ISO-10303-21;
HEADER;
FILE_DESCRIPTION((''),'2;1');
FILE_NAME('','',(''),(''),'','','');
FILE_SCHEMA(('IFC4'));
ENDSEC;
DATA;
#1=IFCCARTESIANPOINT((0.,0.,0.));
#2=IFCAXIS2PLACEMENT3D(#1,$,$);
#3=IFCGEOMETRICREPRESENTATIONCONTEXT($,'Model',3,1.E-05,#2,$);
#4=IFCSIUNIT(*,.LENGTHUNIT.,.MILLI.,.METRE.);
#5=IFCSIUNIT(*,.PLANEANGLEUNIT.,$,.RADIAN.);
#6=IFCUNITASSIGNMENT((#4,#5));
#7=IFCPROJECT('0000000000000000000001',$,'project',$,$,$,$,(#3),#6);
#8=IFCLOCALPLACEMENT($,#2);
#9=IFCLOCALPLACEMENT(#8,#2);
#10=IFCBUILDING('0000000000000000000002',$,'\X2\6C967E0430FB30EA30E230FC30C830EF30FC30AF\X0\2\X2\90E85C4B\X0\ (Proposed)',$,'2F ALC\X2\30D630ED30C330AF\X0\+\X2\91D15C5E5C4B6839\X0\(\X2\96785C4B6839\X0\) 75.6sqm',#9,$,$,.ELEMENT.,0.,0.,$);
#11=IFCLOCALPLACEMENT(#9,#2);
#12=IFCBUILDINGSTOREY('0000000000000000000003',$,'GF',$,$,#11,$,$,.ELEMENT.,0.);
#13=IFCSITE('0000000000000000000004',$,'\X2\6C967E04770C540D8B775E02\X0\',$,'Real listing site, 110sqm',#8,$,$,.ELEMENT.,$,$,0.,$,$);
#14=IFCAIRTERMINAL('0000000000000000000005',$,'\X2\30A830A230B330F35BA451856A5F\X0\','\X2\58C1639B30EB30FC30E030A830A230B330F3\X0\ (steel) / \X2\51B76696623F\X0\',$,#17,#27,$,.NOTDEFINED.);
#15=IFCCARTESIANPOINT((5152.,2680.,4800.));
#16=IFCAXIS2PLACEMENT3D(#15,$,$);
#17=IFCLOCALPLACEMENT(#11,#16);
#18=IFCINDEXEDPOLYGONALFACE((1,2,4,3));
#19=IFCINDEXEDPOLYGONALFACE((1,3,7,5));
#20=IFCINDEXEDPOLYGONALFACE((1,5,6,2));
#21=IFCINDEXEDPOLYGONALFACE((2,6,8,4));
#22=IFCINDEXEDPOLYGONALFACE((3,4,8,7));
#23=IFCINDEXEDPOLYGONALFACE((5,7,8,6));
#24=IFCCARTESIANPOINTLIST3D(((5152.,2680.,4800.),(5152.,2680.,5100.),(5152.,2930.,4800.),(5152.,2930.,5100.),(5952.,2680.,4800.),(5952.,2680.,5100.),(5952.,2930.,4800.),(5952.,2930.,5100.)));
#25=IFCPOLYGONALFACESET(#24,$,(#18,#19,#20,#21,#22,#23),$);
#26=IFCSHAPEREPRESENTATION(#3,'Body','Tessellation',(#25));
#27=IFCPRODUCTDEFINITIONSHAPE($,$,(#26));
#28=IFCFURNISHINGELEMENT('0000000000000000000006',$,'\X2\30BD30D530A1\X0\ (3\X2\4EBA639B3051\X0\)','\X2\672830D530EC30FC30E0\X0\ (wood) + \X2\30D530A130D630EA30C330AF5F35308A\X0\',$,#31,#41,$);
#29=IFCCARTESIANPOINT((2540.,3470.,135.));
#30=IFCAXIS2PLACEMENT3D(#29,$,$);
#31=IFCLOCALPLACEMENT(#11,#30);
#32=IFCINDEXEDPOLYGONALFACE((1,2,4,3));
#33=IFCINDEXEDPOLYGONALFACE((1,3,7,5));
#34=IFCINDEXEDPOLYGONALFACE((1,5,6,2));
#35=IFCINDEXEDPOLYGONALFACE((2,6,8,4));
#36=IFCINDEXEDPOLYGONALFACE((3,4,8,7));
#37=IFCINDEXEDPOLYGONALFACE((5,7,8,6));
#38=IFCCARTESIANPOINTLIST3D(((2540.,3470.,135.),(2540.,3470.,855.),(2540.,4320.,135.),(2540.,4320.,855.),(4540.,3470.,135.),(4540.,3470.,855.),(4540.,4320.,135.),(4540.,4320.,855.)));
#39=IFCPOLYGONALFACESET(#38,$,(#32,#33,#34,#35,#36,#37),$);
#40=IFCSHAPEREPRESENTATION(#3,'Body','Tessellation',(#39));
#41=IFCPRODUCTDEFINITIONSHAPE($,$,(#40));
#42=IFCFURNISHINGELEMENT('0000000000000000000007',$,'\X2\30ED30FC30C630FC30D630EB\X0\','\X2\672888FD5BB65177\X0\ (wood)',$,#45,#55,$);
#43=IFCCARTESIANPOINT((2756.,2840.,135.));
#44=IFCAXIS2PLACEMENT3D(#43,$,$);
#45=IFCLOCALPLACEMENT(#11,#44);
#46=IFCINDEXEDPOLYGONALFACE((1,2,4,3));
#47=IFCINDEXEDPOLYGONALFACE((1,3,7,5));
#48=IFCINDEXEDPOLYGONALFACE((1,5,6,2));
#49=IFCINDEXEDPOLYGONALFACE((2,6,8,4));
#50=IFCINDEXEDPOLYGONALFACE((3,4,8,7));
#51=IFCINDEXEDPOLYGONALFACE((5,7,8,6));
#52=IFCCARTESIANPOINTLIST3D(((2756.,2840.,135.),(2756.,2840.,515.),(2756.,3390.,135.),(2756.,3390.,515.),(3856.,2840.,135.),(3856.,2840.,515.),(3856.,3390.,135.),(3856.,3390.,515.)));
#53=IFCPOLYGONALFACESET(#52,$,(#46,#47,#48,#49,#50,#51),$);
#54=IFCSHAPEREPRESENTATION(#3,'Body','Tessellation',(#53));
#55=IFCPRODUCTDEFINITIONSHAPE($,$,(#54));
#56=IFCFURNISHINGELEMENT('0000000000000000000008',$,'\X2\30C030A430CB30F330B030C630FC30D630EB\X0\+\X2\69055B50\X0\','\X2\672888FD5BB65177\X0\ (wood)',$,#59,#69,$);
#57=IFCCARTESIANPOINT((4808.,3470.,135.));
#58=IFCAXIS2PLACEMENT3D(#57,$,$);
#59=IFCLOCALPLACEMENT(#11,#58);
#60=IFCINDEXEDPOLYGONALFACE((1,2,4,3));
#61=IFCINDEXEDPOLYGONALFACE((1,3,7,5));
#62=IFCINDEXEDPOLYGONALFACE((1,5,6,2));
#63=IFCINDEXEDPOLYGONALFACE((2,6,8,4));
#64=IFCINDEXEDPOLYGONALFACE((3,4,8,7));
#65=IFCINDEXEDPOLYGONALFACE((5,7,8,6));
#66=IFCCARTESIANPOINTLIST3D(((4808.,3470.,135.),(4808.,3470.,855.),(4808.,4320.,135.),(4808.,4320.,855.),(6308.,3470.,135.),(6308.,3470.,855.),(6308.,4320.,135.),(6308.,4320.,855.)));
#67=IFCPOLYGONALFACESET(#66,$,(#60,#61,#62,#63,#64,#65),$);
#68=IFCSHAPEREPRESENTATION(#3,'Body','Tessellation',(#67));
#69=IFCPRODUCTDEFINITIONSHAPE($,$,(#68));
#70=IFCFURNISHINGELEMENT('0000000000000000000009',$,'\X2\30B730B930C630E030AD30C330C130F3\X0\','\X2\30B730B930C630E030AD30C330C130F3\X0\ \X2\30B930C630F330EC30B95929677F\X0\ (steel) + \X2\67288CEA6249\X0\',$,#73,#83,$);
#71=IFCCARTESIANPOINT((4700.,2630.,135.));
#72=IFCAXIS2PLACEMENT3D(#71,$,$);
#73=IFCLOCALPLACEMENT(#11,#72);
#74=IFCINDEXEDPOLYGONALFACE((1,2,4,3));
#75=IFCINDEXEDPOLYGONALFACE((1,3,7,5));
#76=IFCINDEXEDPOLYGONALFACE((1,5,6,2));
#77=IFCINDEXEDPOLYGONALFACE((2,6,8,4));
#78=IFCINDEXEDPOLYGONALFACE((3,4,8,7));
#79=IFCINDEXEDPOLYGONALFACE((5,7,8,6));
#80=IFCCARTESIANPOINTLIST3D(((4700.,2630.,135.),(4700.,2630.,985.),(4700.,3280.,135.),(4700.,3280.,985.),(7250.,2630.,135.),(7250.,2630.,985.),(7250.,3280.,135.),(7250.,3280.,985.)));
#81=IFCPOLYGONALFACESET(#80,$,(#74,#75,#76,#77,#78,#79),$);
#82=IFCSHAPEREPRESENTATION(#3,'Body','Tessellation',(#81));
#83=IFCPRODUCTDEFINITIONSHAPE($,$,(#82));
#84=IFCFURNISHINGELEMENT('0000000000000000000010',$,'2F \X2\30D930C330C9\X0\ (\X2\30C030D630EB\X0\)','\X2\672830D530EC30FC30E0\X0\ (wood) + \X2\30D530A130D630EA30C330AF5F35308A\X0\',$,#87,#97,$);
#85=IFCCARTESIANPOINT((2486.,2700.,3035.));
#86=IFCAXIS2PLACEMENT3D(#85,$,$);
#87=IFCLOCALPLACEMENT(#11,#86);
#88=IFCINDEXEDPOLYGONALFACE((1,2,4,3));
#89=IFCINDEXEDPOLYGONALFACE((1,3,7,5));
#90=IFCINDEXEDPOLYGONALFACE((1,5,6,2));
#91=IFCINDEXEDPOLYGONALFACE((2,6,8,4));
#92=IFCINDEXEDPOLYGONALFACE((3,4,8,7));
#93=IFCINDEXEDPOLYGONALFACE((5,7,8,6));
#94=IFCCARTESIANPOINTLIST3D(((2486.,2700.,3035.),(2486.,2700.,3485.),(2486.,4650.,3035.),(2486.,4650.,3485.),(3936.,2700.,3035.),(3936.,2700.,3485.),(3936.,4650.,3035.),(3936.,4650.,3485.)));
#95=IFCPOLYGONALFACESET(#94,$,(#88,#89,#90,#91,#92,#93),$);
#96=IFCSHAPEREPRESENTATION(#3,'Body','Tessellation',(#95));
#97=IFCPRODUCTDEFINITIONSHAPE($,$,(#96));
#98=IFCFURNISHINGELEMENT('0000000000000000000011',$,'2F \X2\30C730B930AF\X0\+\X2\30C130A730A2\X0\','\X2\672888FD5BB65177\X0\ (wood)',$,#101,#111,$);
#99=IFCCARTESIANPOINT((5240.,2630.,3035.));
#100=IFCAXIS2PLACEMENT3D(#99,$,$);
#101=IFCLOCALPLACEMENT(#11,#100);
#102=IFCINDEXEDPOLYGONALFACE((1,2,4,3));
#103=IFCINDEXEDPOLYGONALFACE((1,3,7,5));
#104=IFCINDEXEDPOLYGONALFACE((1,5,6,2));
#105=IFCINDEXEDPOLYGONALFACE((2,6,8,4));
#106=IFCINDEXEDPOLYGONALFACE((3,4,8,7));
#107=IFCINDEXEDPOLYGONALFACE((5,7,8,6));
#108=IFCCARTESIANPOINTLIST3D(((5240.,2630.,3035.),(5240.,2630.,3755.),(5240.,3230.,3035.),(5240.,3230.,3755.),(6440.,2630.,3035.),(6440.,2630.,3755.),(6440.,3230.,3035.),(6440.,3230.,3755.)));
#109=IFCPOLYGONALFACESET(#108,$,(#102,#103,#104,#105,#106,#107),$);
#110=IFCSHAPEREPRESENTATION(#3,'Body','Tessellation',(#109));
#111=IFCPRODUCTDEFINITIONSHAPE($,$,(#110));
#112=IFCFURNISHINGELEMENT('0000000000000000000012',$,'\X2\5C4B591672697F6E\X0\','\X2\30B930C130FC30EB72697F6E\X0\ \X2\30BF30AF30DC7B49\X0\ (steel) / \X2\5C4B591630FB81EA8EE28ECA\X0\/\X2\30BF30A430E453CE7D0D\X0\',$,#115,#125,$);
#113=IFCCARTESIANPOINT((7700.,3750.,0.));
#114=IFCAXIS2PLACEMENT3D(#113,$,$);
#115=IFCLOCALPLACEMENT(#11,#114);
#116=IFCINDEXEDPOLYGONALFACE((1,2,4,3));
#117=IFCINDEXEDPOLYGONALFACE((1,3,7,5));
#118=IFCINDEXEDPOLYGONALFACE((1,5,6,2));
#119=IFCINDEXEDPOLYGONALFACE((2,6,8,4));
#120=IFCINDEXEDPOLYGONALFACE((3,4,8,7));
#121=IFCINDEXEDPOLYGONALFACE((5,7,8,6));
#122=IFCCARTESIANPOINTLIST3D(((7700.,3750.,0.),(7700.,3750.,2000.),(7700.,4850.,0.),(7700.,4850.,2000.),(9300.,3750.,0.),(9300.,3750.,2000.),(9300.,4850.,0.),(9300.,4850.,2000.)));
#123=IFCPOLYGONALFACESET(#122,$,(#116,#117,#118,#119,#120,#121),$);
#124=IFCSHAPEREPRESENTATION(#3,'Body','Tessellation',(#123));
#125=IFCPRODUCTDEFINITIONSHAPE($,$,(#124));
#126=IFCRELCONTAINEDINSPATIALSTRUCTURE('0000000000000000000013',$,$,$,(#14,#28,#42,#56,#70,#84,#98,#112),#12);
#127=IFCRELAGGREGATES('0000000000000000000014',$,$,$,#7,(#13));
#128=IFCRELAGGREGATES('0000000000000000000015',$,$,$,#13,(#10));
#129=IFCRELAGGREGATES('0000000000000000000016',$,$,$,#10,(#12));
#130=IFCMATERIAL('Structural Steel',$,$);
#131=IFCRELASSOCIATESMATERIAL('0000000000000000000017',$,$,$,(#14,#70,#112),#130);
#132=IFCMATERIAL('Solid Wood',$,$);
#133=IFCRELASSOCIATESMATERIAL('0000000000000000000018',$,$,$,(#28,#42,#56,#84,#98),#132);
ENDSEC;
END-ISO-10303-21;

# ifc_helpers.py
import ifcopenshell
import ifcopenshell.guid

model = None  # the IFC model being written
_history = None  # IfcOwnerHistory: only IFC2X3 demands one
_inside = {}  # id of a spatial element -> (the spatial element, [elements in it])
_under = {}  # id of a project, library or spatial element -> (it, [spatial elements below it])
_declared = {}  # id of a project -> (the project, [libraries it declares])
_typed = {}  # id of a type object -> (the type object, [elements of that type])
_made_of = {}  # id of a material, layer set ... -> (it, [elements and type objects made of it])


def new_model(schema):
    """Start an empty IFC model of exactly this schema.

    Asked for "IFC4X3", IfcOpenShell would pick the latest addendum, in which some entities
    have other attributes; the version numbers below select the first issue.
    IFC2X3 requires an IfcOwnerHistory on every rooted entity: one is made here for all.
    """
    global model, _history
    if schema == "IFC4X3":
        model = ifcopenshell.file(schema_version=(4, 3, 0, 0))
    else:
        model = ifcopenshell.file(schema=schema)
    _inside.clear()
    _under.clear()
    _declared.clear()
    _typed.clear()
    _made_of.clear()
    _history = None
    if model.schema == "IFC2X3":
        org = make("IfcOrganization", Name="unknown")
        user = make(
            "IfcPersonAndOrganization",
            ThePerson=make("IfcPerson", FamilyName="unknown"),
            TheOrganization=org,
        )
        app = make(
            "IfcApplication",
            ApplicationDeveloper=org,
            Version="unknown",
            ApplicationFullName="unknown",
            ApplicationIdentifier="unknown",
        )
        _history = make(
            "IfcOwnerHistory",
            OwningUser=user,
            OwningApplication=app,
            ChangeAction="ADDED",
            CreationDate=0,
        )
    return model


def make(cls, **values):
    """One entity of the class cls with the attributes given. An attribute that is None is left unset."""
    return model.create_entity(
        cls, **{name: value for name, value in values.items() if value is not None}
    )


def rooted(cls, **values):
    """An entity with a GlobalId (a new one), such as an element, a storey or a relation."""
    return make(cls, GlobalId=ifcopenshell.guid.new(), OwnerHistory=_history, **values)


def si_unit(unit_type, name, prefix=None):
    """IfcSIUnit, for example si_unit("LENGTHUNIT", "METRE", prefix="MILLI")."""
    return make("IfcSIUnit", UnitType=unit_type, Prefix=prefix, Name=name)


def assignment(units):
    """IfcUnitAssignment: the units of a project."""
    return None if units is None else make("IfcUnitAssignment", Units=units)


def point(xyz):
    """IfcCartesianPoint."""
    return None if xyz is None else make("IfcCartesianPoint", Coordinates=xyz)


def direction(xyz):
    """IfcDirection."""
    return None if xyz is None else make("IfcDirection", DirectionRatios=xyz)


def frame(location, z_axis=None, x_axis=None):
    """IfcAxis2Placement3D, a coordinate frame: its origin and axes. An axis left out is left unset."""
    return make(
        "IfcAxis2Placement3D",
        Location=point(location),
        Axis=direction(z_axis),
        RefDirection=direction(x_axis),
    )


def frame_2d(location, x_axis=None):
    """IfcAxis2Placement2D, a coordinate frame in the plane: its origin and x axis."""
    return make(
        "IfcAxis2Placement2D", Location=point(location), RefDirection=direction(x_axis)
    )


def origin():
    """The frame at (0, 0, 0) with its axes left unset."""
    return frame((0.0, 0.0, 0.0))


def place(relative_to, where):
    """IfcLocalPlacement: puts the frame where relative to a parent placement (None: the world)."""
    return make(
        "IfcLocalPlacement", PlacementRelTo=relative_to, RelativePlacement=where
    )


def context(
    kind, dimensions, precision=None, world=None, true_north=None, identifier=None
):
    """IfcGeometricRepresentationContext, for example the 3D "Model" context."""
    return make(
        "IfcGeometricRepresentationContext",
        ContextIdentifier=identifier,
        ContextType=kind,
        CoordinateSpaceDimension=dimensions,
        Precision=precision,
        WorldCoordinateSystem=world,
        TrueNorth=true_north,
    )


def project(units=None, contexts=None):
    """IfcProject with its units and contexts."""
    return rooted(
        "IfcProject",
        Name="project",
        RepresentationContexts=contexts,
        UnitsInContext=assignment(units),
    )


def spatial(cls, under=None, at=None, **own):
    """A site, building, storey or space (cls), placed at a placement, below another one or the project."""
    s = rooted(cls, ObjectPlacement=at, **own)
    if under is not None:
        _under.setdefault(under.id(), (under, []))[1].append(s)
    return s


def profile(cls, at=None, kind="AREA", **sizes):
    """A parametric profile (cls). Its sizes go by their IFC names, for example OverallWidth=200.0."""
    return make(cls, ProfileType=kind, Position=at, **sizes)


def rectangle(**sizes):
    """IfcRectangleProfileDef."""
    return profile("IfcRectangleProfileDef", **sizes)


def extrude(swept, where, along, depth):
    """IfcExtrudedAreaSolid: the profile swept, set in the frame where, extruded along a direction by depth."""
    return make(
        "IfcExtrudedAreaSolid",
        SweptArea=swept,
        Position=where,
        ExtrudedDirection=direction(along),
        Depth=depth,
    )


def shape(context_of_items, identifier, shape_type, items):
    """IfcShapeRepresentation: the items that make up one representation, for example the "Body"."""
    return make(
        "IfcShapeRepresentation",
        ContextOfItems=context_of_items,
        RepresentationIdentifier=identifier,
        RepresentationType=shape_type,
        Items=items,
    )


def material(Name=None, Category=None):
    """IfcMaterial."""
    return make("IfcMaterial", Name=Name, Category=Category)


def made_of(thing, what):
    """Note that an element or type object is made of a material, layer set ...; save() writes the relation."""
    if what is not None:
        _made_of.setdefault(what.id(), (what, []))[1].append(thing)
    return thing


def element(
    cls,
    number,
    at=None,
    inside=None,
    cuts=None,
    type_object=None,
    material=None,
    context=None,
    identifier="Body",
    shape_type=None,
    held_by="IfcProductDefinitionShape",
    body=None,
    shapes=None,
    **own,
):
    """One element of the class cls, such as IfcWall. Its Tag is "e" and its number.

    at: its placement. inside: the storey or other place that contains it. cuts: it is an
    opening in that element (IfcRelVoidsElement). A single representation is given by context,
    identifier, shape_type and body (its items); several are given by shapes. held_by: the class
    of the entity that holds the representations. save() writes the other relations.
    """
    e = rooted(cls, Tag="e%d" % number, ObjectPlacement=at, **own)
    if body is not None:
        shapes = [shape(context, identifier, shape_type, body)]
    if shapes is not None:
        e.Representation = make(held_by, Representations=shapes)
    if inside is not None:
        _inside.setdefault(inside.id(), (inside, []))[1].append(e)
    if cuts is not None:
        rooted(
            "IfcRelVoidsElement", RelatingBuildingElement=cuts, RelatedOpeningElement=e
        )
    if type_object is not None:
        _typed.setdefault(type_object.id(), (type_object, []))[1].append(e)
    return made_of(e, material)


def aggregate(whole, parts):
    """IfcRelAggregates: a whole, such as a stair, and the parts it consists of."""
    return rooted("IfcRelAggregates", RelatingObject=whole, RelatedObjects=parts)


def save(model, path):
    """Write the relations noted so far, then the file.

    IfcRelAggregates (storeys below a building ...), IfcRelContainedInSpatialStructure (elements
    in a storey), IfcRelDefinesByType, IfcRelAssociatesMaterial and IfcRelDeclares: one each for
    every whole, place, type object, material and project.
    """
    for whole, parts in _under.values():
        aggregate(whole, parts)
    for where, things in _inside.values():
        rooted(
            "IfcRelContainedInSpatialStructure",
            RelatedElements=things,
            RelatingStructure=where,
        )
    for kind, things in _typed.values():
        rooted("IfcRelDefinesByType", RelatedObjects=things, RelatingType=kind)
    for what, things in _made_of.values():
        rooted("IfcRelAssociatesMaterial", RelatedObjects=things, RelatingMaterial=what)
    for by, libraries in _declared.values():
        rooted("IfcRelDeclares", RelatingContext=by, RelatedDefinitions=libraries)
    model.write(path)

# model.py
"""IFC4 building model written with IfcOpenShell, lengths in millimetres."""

from ifc_helpers import new_model, si_unit, frame, frame_2d, origin, place, context, project, spatial, rectangle, extrude, material, element, save


model = new_model("IFC4")

# Units and contexts
model_context = context("Model", 3, precision=1e-05, world=origin())
ifc_project = project(units=[si_unit("LENGTHUNIT", "METRE", prefix="MILLI"), si_unit("PLANEANGLEUNIT", "RADIAN")], contexts=[model_context])

# Site, building, storey
site_placement = place(None, origin())
site = spatial("IfcSite", under=ifc_project, at=site_placement, Name="沖縄県名護市", ObjectType="Real listing site, 110sqm", CompositionType="ELEMENT", RefElevation=0.0)
building_placement = place(site_placement, origin())
building = spatial("IfcBuilding", under=site, at=building_placement, Name="沖縄・リモートワーク2部屋 (Proposed)", ObjectType="2F ALCブロック+金属屋根(陸屋根) 75.6sqm", CompositionType="ELEMENT", ElevationOfRefHeight=0.0, ElevationOfTerrain=0.0)
storey_placement = place(building_placement, origin())
storey = spatial("IfcBuildingStorey", under=building, at=storey_placement, Name="GF", CompositionType="ELEMENT", Elevation=0.0)

# Shared definitions
ifc_material_1 = material(Name="Solid Wood")

# Shared definitions
ifc_material_2 = material(Name="Structural Steel")

# Air terminal
air_terminal_1_placement = place(storey_placement, frame((5152.0, 2680.0, 4800.0)))
element("IfcAirTerminal", 1, at=air_terminal_1_placement, inside=storey, material=ifc_material_2, Name="エアコン室内機", Description="壁掛ルームエアコン (steel) / 冷暖房", PredefinedType="NOTDEFINED", context=model_context, shape_type="SweptSolid", body=[
    extrude(rectangle(XDim=800.0, YDim=250.0, at=frame_2d((400.0, 125.0))), frame((5152.0, 2680.0, 4800.0)), (0.0, 0.0, 1.0), 300.0),
])

# Furnishing elements
furnishing_1_placement = place(storey_placement, frame((2540.0, 3470.0, 135.0)))
element("IfcFurnishingElement", 2, at=furnishing_1_placement, inside=storey, material=ifc_material_1, Name="ソファ (3人掛け)", Description="木フレーム (wood) + ファブリック張り", context=model_context, shape_type="SweptSolid", body=[
    extrude(rectangle(XDim=2000.0, YDim=850.0, at=frame_2d((1000.0, 425.0))), frame((2540.0, 3470.0, 135.0)), (0.0, 0.0, 1.0), 720.0),
])
furnishing_2_placement = place(storey_placement, frame((2756.0, 2840.0, 135.0)))
element("IfcFurnishingElement", 3, at=furnishing_2_placement, inside=storey, material=ifc_material_1, Name="ローテーブル", Description="木製家具 (wood)", context=model_context, shape_type="SweptSolid", body=[
    extrude(rectangle(XDim=1100.0, YDim=550.0, at=frame_2d((550.0, 275.0))), frame((2756.0, 2840.0, 135.0)), (0.0, 0.0, 1.0), 380.0),
])
furnishing_3_placement = place(storey_placement, frame((4808.0, 3470.0, 135.0)))
element("IfcFurnishingElement", 4, at=furnishing_3_placement, inside=storey, material=ifc_material_1, Name="ダイニングテーブル+椅子", Description="木製家具 (wood)", context=model_context, shape_type="SweptSolid", body=[
    extrude(rectangle(XDim=1500.0, YDim=850.0, at=frame_2d((750.0, 425.0))), frame((4808.0, 3470.0, 135.0)), (0.0, 0.0, 1.0), 720.0),
])
furnishing_4_placement = place(storey_placement, frame((4700.0, 2630.0, 135.0)))
element("IfcFurnishingElement", 5, at=furnishing_4_placement, inside=storey, material=ifc_material_2, Name="システムキッチン", Description="システムキッチン ステンレス天板 (steel) + 木質扉", context=model_context, shape_type="SweptSolid", body=[
    extrude(rectangle(XDim=2550.0, YDim=650.0, at=frame_2d((1275.0, 325.0))), frame((4700.0, 2630.0, 135.0)), (0.0, 0.0, 1.0), 850.0),
])
furnishing_5_placement = place(storey_placement, frame((2486.0, 2700.0, 3035.0)))
element("IfcFurnishingElement", 6, at=furnishing_5_placement, inside=storey, material=ifc_material_1, Name="2F ベッド (ダブル)", Description="木フレーム (wood) + ファブリック張り", context=model_context, shape_type="SweptSolid", body=[
    extrude(rectangle(XDim=1450.0, YDim=1950.0, at=frame_2d((725.0, 975.0))), frame((2486.0, 2700.0, 3035.0)), (0.0, 0.0, 1.0), 450.0),
])
furnishing_6_placement = place(storey_placement, frame((5240.0, 2630.0, 3035.0)))
element("IfcFurnishingElement", 7, at=furnishing_6_placement, inside=storey, material=ifc_material_1, Name="2F デスク+チェア", Description="木製家具 (wood)", context=model_context, shape_type="SweptSolid", body=[
    extrude(rectangle(XDim=1200.0, YDim=600.0, at=frame_2d((600.0, 300.0))), frame((5240.0, 2630.0, 3035.0)), (0.0, 0.0, 1.0), 720.0),
])
furnishing_7_placement = place(storey_placement, frame((7700.0, 3750.0, 0.0)))
element("IfcFurnishingElement", 8, at=furnishing_7_placement, inside=storey, material=ifc_material_2, Name="屋外物置", Description="スチール物置 タクボ等 (steel) / 屋外・自転車/タイヤ収納", context=model_context, shape_type="SweptSolid", body=[
    extrude(rectangle(XDim=1600.0, YDim=1100.0, at=frame_2d((800.0, 550.0))), frame((7700.0, 3750.0, 0.0)), (0.0, 0.0, 1.0), 2000.0),
])

save(model, "model.ifc")
